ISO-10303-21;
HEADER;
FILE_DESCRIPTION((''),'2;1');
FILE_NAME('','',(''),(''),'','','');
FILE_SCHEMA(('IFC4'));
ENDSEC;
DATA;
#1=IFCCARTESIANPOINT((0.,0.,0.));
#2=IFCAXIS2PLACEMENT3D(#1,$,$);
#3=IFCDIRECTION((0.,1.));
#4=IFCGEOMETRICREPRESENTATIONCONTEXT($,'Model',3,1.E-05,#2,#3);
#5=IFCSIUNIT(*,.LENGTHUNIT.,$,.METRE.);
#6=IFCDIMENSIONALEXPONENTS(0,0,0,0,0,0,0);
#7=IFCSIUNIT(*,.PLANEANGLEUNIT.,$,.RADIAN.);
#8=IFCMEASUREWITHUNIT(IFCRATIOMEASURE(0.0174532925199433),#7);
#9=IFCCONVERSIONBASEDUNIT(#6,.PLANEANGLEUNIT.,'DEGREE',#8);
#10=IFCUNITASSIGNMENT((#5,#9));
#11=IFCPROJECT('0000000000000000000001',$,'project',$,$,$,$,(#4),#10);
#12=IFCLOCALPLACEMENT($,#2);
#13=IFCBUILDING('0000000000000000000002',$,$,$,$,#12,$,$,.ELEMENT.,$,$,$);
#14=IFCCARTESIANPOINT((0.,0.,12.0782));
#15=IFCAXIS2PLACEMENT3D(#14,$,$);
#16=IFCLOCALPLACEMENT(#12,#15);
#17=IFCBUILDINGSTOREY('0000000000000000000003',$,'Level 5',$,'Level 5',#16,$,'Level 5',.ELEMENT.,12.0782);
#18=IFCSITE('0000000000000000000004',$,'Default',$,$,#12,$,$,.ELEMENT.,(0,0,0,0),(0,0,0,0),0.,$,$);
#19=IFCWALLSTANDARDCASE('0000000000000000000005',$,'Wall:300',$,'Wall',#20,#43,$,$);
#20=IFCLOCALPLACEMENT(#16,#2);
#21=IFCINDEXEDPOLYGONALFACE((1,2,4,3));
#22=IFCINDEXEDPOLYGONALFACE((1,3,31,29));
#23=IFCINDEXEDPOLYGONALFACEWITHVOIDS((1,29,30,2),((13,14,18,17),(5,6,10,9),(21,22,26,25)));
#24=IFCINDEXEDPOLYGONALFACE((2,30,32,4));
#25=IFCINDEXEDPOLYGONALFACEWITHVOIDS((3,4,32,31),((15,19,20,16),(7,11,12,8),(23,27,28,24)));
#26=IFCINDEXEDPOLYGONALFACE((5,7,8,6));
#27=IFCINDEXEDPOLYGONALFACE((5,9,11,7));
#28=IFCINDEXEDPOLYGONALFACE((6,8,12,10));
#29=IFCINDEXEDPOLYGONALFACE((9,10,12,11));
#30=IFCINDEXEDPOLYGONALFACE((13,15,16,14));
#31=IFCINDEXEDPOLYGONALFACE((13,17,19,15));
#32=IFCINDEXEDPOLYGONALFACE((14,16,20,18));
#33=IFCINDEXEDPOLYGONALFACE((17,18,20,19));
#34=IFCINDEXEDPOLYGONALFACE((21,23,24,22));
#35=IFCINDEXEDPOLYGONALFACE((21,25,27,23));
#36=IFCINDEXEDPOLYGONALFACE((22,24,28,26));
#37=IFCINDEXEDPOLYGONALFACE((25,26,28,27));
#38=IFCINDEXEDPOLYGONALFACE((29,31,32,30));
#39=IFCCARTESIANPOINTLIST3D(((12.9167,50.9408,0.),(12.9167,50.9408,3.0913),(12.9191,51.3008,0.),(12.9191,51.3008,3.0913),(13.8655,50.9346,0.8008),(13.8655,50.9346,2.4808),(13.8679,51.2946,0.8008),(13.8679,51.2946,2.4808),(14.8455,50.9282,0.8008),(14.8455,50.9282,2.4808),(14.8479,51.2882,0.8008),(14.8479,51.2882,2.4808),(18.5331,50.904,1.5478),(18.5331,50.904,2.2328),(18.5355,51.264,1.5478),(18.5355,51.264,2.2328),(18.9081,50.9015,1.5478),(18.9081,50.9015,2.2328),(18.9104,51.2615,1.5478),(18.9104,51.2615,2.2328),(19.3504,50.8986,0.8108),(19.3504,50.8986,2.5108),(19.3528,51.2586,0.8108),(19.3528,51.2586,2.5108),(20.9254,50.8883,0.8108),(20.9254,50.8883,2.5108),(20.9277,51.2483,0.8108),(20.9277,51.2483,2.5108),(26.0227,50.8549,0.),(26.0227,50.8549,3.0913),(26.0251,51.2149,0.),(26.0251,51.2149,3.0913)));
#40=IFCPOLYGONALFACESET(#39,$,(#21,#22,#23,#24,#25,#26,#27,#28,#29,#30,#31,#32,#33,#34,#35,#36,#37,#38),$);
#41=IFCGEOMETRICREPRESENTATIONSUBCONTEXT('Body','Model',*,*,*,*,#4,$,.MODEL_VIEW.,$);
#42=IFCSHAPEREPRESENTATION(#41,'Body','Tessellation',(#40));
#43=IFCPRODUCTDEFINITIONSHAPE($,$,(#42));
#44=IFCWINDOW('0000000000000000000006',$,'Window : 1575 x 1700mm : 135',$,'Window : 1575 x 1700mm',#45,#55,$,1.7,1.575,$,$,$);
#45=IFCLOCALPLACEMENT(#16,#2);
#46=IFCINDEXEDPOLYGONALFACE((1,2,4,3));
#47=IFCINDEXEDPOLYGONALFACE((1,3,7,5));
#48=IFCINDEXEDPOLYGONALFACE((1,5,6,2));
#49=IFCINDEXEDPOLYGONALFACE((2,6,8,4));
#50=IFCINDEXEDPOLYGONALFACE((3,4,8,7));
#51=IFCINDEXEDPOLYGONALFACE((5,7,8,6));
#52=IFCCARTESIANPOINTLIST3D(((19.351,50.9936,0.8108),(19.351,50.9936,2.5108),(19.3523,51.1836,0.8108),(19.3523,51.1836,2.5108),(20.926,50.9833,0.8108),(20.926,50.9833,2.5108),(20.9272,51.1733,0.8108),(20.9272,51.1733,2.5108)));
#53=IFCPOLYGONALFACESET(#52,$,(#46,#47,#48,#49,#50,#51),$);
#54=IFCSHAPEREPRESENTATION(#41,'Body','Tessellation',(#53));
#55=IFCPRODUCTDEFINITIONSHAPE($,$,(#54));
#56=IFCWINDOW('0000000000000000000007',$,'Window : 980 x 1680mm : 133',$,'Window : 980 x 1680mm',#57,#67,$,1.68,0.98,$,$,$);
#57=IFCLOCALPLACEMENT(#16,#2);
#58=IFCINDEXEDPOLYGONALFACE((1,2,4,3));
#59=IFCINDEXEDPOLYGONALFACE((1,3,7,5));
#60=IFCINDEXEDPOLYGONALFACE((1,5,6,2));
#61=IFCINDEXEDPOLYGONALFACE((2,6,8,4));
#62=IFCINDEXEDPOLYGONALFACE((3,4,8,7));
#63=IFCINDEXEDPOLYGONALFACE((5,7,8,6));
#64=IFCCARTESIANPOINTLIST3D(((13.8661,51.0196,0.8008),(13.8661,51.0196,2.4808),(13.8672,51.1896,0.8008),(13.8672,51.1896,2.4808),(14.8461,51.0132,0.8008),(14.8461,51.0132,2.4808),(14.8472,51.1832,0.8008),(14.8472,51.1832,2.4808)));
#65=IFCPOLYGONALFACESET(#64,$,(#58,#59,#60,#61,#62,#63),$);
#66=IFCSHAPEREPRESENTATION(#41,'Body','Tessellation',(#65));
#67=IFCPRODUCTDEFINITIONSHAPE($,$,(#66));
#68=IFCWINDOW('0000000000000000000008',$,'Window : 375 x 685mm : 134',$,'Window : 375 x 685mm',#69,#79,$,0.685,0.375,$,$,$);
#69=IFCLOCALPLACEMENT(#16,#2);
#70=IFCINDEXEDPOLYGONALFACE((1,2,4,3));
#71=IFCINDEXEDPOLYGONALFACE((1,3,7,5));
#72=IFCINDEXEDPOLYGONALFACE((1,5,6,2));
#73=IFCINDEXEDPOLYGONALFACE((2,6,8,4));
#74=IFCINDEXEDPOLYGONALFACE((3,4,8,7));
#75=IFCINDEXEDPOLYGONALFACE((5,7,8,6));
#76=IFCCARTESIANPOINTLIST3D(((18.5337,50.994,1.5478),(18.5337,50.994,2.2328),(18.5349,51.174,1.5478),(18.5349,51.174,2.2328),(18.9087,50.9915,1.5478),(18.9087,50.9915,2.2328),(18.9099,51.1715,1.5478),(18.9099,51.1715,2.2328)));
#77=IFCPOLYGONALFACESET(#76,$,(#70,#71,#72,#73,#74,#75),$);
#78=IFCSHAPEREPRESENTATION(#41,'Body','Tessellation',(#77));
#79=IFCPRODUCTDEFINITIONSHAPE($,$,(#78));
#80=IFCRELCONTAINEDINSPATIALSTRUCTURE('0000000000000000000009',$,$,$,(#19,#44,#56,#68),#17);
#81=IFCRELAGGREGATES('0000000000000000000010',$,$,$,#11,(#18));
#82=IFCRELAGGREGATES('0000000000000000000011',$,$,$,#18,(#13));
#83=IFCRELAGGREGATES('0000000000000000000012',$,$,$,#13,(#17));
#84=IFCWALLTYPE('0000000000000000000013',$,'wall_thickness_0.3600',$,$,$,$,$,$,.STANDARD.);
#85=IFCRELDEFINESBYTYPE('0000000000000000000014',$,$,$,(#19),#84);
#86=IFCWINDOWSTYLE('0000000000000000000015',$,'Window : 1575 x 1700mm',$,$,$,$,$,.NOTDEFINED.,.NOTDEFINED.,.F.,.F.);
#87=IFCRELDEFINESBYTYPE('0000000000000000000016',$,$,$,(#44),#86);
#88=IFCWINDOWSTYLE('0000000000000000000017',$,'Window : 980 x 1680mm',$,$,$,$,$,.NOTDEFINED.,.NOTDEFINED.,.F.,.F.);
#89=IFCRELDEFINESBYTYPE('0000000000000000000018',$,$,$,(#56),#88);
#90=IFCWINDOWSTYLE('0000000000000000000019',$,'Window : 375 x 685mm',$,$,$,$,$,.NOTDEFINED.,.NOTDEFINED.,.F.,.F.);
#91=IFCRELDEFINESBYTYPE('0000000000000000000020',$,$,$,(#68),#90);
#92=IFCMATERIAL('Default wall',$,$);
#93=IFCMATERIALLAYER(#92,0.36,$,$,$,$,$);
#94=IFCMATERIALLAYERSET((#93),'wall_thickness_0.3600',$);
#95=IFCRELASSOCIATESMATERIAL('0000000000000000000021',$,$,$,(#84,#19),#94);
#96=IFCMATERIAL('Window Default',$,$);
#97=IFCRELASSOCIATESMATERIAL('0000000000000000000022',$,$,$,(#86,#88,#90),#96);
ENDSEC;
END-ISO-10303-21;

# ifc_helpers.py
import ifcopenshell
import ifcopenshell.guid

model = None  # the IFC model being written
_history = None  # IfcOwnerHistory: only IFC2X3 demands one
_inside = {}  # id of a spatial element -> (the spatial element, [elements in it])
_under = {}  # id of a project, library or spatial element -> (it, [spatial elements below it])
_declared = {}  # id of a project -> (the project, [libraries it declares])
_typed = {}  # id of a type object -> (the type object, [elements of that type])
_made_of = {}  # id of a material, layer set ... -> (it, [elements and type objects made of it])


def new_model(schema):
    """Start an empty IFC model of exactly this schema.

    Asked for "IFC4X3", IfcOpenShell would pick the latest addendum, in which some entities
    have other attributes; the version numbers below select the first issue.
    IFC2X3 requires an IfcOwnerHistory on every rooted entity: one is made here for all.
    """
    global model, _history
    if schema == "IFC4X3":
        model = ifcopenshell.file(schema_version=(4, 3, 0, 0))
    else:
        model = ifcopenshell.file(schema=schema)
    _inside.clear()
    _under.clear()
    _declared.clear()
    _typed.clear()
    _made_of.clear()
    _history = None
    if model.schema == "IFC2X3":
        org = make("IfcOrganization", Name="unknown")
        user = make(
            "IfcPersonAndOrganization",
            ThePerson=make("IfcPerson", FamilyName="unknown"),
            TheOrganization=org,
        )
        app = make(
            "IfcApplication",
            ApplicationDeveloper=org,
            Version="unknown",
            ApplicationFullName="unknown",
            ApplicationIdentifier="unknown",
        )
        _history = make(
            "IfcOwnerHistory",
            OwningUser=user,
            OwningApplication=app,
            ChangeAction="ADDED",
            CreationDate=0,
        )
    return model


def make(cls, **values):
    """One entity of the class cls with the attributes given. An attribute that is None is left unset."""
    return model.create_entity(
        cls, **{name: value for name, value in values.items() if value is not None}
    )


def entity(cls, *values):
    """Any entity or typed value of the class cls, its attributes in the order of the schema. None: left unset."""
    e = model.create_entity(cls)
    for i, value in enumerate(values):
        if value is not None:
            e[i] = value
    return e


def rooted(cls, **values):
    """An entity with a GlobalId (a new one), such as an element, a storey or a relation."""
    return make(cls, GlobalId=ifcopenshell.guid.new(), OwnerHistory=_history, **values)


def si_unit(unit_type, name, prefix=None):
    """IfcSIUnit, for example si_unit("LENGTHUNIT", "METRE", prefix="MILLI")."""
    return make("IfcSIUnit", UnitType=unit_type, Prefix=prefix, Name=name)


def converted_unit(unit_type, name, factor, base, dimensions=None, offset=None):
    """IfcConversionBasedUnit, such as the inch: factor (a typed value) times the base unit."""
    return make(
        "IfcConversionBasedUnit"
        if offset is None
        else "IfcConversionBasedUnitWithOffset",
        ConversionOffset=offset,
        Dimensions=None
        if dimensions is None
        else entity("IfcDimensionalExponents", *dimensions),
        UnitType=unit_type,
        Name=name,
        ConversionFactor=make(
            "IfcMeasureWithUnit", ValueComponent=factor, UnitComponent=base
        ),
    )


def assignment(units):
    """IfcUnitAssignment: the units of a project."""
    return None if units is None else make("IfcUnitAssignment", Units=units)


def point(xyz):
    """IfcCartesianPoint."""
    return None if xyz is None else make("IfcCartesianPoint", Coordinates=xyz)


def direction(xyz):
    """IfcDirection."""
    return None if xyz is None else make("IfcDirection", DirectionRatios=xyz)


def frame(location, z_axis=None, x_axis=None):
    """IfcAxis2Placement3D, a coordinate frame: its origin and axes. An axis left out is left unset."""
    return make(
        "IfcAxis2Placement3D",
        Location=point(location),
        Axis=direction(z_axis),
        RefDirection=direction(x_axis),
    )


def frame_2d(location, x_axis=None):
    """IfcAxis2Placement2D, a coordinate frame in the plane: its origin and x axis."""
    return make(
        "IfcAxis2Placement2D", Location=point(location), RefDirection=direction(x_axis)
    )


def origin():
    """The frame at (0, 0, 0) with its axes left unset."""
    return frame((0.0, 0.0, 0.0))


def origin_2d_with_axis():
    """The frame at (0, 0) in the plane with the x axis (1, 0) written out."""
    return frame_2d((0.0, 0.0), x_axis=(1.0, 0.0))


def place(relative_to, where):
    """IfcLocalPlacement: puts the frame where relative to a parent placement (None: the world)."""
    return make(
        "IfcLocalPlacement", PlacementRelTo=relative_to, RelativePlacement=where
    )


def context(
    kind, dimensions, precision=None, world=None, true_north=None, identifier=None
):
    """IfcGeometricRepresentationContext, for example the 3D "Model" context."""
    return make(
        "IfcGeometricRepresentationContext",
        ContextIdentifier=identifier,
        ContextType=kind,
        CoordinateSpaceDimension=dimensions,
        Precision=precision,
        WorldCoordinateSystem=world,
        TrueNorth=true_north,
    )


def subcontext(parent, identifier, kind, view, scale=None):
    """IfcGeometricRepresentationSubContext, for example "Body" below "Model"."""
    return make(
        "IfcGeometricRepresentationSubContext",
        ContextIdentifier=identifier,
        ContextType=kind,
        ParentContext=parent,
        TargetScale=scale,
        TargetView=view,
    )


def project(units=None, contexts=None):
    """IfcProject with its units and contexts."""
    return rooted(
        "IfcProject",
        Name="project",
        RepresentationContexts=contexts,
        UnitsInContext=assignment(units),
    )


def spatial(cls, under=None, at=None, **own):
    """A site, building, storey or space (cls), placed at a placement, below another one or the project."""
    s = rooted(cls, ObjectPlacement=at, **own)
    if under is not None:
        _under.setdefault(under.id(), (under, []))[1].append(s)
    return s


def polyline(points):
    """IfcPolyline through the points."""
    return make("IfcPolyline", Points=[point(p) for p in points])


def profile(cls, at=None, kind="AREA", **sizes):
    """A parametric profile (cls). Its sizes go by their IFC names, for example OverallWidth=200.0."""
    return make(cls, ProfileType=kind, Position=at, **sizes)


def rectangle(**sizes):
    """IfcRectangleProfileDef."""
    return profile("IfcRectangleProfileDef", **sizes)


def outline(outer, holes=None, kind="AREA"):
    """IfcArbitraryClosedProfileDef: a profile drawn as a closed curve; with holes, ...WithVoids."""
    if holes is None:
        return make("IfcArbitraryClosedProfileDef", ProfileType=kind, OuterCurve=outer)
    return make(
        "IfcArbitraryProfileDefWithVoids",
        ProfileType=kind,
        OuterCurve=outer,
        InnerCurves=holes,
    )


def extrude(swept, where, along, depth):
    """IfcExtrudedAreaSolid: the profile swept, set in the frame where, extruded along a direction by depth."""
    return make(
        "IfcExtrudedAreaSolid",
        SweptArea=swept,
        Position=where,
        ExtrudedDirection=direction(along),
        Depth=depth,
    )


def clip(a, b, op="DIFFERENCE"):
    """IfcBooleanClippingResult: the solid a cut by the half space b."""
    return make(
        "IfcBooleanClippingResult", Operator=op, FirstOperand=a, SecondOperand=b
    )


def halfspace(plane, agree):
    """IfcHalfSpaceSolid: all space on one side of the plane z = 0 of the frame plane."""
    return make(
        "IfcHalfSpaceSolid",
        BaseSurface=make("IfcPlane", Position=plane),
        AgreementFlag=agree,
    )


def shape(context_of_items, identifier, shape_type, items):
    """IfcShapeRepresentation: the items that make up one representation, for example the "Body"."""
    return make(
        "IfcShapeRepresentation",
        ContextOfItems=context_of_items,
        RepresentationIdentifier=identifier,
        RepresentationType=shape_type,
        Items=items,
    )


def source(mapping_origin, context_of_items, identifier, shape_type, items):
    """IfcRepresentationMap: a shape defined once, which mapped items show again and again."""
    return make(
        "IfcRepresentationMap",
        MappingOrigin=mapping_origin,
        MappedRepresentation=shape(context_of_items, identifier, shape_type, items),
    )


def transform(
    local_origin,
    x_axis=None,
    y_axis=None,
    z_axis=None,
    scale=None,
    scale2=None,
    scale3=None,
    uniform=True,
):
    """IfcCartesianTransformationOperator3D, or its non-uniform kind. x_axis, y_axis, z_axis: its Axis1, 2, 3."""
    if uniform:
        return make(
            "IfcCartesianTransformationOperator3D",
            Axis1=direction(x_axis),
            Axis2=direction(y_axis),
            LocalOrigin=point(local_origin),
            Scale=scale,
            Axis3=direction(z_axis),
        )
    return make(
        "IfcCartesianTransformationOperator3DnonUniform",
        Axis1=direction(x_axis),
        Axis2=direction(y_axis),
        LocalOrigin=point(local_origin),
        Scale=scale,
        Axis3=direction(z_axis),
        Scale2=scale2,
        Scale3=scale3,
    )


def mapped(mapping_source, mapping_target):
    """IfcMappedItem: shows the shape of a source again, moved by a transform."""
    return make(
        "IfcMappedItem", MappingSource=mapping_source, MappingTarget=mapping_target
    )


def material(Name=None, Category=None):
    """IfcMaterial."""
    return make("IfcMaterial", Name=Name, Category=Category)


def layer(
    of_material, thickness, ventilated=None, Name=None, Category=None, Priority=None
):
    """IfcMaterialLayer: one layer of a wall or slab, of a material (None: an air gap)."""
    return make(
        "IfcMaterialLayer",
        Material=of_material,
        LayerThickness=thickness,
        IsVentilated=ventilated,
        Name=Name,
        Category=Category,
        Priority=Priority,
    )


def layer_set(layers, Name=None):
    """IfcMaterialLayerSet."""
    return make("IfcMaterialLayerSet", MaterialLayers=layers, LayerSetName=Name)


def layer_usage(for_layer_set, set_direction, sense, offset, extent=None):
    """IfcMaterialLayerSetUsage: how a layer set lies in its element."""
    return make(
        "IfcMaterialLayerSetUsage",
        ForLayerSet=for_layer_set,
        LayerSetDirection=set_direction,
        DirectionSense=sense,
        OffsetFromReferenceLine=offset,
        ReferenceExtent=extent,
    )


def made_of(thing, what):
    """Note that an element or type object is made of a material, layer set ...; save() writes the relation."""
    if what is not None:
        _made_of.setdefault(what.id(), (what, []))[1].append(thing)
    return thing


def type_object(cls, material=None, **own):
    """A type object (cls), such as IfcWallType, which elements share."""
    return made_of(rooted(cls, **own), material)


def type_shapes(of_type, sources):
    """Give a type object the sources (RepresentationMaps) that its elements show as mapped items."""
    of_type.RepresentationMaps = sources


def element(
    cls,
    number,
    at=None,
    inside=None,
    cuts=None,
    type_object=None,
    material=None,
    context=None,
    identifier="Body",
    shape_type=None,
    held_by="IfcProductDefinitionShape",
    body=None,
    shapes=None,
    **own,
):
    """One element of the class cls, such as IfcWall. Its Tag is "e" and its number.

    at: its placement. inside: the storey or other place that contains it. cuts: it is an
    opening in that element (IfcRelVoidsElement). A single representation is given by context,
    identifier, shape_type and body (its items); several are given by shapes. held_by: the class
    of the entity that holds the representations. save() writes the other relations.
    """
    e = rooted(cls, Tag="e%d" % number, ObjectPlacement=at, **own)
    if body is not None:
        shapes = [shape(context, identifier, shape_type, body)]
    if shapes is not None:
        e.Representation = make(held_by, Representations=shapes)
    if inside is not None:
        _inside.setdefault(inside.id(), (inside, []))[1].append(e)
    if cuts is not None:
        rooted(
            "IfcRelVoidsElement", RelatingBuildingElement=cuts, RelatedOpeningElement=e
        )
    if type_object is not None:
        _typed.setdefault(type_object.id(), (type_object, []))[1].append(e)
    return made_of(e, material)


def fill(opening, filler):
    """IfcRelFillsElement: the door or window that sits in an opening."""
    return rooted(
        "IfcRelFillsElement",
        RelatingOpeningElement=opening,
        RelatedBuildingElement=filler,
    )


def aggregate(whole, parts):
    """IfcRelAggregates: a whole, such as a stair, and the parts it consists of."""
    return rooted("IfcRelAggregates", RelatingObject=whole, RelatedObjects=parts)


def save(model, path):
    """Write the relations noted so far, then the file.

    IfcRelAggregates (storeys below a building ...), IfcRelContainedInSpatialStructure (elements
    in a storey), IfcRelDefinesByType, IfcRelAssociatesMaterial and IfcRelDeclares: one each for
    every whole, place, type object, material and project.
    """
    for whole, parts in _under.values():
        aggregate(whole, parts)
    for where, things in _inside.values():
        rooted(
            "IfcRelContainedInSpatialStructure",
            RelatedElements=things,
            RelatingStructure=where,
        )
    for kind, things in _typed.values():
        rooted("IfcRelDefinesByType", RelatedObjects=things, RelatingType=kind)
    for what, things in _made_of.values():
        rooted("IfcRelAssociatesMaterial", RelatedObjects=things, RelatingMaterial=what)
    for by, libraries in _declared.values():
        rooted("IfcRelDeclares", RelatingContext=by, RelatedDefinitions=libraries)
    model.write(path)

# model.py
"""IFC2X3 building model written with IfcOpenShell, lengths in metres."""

from ifc_helpers import new_model, entity, si_unit, converted_unit, direction, frame, frame_2d, origin, origin_2d_with_axis, place, context, subcontext, project, spatial, polyline, rectangle, outline, extrude, clip, halfspace, source, transform, mapped, material, layer, layer_set, layer_usage, type_object, type_shapes, element, fill, save


model = new_model("IFC2X3")

# Units and contexts
model_context = context("Model", 3, precision=1e-05, world=origin(), true_north=direction((0.0, 1.0)))
body_context = subcontext(model_context, "Body", "Model", "MODEL_VIEW")
ifc_project = project(units=[si_unit("LENGTHUNIT", "METRE"), converted_unit("PLANEANGLEUNIT", "DEGREE", entity("IfcRatioMeasure", 0.0174532925199433), si_unit("PLANEANGLEUNIT", "RADIAN"), dimensions=[0, 0, 0, 0, 0, 0, 0])], contexts=[model_context])

# Site, building, storey
placement = place(None, origin())
site = spatial("IfcSite", under=ifc_project, at=placement, Name="Default", CompositionType="ELEMENT", RefLatitude=(0, 0, 0, 0), RefLongitude=(0, 0, 0, 0), RefElevation=0.0)
building = spatial("IfcBuilding", under=site, at=placement, CompositionType="ELEMENT")
storey_placement = place(placement, frame((0.0, 0.0, 12.0782)))
storey = spatial("IfcBuildingStorey", under=building, at=storey_placement, Name="Level 5", ObjectType="Level 5", LongName="Level 5", CompositionType="ELEMENT", Elevation=12.0782)

# Shared definitions
ifc_material_1 = material(Name="Default wall")

# Wall, openings, windows
ifc_material_2 = material(Name="Window Default")
ifc_layer_1 = layer(ifc_material_1, 0.36)
ifc_layer_set_1 = layer_set([ifc_layer_1], Name="wall_thickness_0.3600")
ifc_layer_usage_1 = layer_usage(ifc_layer_set_1, "AXIS2", "POSITIVE", -0.18)
wall_type_1 = type_object("IfcWallType", Name="wall_thickness_0.3600", PredefinedType="STANDARD", material=ifc_layer_set_1)
wall_1_placement = place(storey_placement, frame((12.9179, 51.1208, 0.0), z_axis=(0.0, 0.0, 1.0), x_axis=(0.999978, -0.006559, 0.0)))
wall_1 = element("IfcWallStandardCase", 1, at=wall_1_placement, inside=storey, type_object=wall_type_1, material=ifc_layer_usage_1, Name="Wall:300", ObjectType="Wall", context=body_context, shape_type="Clipping", body=[
    clip(extrude(outline(polyline([(13.1062, -0.18), (13.1062, 0.18), (0.0, 0.18), (0.0, -0.18), (13.1062, -0.18)])), origin(), (0.0, 0.0, 1.0), 3.0913), halfspace(frame((-25.7144, 6.5179, 9.0175), z_axis=(-0.001323, -0.391128, 0.920336), x_axis=(0.999998, -0.001591, 0.000761)), False)),
])
opening_1_placement = place(wall_1_placement, frame((0.9488, -0.18, 0.8008)))
opening_1 = element("IfcOpeningElement", 2, at=opening_1_placement, cuts=wall_1, ObjectType="Opening", context=body_context, shape_type="SweptSolid", body=[
    extrude(rectangle(XDim=0.98, YDim=1.68, at=frame_2d((0.84, 0.49), x_axis=(0.0, 1.0))), frame((0.0, 0.0, 0.0), z_axis=(0.0, 1.0, 0.0), x_axis=(0.0, 0.0, 1.0)), (0.0, 0.0, 1.0), 0.36),
])
opening_2_placement = place(wall_1_placement, frame((5.6165, -0.18, 1.5478)))
opening_2 = element("IfcOpeningElement", 3, at=opening_2_placement, cuts=wall_1, ObjectType="Opening", context=body_context, shape_type="SweptSolid", body=[
    extrude(rectangle(XDim=0.375, YDim=0.685, at=frame_2d((0.3425, 0.1875), x_axis=(0.0, 1.0))), frame((0.0, 0.0, 0.0), z_axis=(0.0, 1.0, 0.0), x_axis=(0.0, 0.0, 1.0)), (0.0, 0.0, 1.0), 0.36),
])
opening_3_placement = place(wall_1_placement, frame((6.4338, -0.18, 0.8108)))
opening_3 = element("IfcOpeningElement", 4, at=opening_3_placement, cuts=wall_1, ObjectType="Opening", context=body_context, shape_type="SweptSolid", body=[
    extrude(rectangle(XDim=1.575, YDim=1.7, at=frame_2d((0.85, 0.7875), x_axis=(0.0, 1.0))), frame((0.0, 0.0, 0.0), z_axis=(0.0, 1.0, 0.0), x_axis=(0.0, 0.0, 1.0)), (0.0, 0.0, 1.0), 0.36),
])
window_style_1 = type_object("IfcWindowStyle", Name="Window : 1575 x 1700mm", ConstructionType="NOTDEFINED", OperationType="NOTDEFINED", ParameterTakesPrecedence=False, Sizeable=False, material=ifc_material_2)
shared_shape_1 = source(origin(), body_context, "Body", "SweptSolid", [
    extrude(rectangle(XDim=0.19, YDim=1.575, at=origin_2d_with_axis()), frame((0.7875, 0.19, 0.0), z_axis=(0.0, 0.0, 1.0), x_axis=(0.0, 1.0, 0.0)), (0.0, 0.0, 1.0), 1.7),
])
type_shapes(window_style_1, [shared_shape_1])
window_1_placement = place(opening_3_placement, origin())
window_1 = element("IfcWindow", 5, at=window_1_placement, inside=storey, type_object=window_style_1, Name="Window : 1575 x 1700mm : 135", ObjectType="Window : 1575 x 1700mm", OverallHeight=1.7, OverallWidth=1.575, context=body_context, shape_type="MappedRepresentation", body=[
    mapped(shared_shape_1, transform((0.0, 0.0, 0.0), scale=1.0)),
])
fill(opening_3, window_1)
window_style_2 = type_object("IfcWindowStyle", Name="Window : 980 x 1680mm", ConstructionType="NOTDEFINED", OperationType="NOTDEFINED", ParameterTakesPrecedence=False, Sizeable=False, material=ifc_material_2)
shared_shape_2 = source(origin(), body_context, "Body", "SweptSolid", [
    extrude(rectangle(XDim=0.17, YDim=0.98, at=origin_2d_with_axis()), frame((0.49, 0.17, 0.0), z_axis=(0.0, 0.0, 1.0), x_axis=(0.0, 1.0, 0.0)), (0.0, 0.0, 1.0), 1.68),
])
type_shapes(window_style_2, [shared_shape_2])
window_2_placement = place(opening_1_placement, origin())
window_2 = element("IfcWindow", 6, at=window_2_placement, inside=storey, type_object=window_style_2, Name="Window : 980 x 1680mm : 133", ObjectType="Window : 980 x 1680mm", OverallHeight=1.68, OverallWidth=0.98, context=body_context, shape_type="MappedRepresentation", body=[
    mapped(shared_shape_2, transform((0.0, 0.0, 0.0), scale=1.0)),
])
fill(opening_1, window_2)
window_style_3 = type_object("IfcWindowStyle", Name="Window : 375 x 685mm", ConstructionType="NOTDEFINED", OperationType="NOTDEFINED", ParameterTakesPrecedence=False, Sizeable=False, material=ifc_material_2)
shared_shape_3 = source(origin(), body_context, "Body", "SweptSolid", [
    extrude(rectangle(XDim=0.18, YDim=0.375, at=origin_2d_with_axis()), frame((0.1875, 0.18, 0.0), z_axis=(0.0, 0.0, 1.0), x_axis=(0.0, 1.0, 0.0)), (0.0, 0.0, 1.0), 0.685),
])
type_shapes(window_style_3, [shared_shape_3])
window_3_placement = place(opening_2_placement, origin())
window_3 = element("IfcWindow", 7, at=window_3_placement, inside=storey, type_object=window_style_3, Name="Window : 375 x 685mm : 134", ObjectType="Window : 375 x 685mm", OverallHeight=0.685, OverallWidth=0.375, context=body_context, shape_type="MappedRepresentation", body=[
    mapped(shared_shape_3, transform((0.0, 0.0, 0.0), scale=1.0)),
])
fill(opening_2, window_3)

save(model, "model.ifc")
